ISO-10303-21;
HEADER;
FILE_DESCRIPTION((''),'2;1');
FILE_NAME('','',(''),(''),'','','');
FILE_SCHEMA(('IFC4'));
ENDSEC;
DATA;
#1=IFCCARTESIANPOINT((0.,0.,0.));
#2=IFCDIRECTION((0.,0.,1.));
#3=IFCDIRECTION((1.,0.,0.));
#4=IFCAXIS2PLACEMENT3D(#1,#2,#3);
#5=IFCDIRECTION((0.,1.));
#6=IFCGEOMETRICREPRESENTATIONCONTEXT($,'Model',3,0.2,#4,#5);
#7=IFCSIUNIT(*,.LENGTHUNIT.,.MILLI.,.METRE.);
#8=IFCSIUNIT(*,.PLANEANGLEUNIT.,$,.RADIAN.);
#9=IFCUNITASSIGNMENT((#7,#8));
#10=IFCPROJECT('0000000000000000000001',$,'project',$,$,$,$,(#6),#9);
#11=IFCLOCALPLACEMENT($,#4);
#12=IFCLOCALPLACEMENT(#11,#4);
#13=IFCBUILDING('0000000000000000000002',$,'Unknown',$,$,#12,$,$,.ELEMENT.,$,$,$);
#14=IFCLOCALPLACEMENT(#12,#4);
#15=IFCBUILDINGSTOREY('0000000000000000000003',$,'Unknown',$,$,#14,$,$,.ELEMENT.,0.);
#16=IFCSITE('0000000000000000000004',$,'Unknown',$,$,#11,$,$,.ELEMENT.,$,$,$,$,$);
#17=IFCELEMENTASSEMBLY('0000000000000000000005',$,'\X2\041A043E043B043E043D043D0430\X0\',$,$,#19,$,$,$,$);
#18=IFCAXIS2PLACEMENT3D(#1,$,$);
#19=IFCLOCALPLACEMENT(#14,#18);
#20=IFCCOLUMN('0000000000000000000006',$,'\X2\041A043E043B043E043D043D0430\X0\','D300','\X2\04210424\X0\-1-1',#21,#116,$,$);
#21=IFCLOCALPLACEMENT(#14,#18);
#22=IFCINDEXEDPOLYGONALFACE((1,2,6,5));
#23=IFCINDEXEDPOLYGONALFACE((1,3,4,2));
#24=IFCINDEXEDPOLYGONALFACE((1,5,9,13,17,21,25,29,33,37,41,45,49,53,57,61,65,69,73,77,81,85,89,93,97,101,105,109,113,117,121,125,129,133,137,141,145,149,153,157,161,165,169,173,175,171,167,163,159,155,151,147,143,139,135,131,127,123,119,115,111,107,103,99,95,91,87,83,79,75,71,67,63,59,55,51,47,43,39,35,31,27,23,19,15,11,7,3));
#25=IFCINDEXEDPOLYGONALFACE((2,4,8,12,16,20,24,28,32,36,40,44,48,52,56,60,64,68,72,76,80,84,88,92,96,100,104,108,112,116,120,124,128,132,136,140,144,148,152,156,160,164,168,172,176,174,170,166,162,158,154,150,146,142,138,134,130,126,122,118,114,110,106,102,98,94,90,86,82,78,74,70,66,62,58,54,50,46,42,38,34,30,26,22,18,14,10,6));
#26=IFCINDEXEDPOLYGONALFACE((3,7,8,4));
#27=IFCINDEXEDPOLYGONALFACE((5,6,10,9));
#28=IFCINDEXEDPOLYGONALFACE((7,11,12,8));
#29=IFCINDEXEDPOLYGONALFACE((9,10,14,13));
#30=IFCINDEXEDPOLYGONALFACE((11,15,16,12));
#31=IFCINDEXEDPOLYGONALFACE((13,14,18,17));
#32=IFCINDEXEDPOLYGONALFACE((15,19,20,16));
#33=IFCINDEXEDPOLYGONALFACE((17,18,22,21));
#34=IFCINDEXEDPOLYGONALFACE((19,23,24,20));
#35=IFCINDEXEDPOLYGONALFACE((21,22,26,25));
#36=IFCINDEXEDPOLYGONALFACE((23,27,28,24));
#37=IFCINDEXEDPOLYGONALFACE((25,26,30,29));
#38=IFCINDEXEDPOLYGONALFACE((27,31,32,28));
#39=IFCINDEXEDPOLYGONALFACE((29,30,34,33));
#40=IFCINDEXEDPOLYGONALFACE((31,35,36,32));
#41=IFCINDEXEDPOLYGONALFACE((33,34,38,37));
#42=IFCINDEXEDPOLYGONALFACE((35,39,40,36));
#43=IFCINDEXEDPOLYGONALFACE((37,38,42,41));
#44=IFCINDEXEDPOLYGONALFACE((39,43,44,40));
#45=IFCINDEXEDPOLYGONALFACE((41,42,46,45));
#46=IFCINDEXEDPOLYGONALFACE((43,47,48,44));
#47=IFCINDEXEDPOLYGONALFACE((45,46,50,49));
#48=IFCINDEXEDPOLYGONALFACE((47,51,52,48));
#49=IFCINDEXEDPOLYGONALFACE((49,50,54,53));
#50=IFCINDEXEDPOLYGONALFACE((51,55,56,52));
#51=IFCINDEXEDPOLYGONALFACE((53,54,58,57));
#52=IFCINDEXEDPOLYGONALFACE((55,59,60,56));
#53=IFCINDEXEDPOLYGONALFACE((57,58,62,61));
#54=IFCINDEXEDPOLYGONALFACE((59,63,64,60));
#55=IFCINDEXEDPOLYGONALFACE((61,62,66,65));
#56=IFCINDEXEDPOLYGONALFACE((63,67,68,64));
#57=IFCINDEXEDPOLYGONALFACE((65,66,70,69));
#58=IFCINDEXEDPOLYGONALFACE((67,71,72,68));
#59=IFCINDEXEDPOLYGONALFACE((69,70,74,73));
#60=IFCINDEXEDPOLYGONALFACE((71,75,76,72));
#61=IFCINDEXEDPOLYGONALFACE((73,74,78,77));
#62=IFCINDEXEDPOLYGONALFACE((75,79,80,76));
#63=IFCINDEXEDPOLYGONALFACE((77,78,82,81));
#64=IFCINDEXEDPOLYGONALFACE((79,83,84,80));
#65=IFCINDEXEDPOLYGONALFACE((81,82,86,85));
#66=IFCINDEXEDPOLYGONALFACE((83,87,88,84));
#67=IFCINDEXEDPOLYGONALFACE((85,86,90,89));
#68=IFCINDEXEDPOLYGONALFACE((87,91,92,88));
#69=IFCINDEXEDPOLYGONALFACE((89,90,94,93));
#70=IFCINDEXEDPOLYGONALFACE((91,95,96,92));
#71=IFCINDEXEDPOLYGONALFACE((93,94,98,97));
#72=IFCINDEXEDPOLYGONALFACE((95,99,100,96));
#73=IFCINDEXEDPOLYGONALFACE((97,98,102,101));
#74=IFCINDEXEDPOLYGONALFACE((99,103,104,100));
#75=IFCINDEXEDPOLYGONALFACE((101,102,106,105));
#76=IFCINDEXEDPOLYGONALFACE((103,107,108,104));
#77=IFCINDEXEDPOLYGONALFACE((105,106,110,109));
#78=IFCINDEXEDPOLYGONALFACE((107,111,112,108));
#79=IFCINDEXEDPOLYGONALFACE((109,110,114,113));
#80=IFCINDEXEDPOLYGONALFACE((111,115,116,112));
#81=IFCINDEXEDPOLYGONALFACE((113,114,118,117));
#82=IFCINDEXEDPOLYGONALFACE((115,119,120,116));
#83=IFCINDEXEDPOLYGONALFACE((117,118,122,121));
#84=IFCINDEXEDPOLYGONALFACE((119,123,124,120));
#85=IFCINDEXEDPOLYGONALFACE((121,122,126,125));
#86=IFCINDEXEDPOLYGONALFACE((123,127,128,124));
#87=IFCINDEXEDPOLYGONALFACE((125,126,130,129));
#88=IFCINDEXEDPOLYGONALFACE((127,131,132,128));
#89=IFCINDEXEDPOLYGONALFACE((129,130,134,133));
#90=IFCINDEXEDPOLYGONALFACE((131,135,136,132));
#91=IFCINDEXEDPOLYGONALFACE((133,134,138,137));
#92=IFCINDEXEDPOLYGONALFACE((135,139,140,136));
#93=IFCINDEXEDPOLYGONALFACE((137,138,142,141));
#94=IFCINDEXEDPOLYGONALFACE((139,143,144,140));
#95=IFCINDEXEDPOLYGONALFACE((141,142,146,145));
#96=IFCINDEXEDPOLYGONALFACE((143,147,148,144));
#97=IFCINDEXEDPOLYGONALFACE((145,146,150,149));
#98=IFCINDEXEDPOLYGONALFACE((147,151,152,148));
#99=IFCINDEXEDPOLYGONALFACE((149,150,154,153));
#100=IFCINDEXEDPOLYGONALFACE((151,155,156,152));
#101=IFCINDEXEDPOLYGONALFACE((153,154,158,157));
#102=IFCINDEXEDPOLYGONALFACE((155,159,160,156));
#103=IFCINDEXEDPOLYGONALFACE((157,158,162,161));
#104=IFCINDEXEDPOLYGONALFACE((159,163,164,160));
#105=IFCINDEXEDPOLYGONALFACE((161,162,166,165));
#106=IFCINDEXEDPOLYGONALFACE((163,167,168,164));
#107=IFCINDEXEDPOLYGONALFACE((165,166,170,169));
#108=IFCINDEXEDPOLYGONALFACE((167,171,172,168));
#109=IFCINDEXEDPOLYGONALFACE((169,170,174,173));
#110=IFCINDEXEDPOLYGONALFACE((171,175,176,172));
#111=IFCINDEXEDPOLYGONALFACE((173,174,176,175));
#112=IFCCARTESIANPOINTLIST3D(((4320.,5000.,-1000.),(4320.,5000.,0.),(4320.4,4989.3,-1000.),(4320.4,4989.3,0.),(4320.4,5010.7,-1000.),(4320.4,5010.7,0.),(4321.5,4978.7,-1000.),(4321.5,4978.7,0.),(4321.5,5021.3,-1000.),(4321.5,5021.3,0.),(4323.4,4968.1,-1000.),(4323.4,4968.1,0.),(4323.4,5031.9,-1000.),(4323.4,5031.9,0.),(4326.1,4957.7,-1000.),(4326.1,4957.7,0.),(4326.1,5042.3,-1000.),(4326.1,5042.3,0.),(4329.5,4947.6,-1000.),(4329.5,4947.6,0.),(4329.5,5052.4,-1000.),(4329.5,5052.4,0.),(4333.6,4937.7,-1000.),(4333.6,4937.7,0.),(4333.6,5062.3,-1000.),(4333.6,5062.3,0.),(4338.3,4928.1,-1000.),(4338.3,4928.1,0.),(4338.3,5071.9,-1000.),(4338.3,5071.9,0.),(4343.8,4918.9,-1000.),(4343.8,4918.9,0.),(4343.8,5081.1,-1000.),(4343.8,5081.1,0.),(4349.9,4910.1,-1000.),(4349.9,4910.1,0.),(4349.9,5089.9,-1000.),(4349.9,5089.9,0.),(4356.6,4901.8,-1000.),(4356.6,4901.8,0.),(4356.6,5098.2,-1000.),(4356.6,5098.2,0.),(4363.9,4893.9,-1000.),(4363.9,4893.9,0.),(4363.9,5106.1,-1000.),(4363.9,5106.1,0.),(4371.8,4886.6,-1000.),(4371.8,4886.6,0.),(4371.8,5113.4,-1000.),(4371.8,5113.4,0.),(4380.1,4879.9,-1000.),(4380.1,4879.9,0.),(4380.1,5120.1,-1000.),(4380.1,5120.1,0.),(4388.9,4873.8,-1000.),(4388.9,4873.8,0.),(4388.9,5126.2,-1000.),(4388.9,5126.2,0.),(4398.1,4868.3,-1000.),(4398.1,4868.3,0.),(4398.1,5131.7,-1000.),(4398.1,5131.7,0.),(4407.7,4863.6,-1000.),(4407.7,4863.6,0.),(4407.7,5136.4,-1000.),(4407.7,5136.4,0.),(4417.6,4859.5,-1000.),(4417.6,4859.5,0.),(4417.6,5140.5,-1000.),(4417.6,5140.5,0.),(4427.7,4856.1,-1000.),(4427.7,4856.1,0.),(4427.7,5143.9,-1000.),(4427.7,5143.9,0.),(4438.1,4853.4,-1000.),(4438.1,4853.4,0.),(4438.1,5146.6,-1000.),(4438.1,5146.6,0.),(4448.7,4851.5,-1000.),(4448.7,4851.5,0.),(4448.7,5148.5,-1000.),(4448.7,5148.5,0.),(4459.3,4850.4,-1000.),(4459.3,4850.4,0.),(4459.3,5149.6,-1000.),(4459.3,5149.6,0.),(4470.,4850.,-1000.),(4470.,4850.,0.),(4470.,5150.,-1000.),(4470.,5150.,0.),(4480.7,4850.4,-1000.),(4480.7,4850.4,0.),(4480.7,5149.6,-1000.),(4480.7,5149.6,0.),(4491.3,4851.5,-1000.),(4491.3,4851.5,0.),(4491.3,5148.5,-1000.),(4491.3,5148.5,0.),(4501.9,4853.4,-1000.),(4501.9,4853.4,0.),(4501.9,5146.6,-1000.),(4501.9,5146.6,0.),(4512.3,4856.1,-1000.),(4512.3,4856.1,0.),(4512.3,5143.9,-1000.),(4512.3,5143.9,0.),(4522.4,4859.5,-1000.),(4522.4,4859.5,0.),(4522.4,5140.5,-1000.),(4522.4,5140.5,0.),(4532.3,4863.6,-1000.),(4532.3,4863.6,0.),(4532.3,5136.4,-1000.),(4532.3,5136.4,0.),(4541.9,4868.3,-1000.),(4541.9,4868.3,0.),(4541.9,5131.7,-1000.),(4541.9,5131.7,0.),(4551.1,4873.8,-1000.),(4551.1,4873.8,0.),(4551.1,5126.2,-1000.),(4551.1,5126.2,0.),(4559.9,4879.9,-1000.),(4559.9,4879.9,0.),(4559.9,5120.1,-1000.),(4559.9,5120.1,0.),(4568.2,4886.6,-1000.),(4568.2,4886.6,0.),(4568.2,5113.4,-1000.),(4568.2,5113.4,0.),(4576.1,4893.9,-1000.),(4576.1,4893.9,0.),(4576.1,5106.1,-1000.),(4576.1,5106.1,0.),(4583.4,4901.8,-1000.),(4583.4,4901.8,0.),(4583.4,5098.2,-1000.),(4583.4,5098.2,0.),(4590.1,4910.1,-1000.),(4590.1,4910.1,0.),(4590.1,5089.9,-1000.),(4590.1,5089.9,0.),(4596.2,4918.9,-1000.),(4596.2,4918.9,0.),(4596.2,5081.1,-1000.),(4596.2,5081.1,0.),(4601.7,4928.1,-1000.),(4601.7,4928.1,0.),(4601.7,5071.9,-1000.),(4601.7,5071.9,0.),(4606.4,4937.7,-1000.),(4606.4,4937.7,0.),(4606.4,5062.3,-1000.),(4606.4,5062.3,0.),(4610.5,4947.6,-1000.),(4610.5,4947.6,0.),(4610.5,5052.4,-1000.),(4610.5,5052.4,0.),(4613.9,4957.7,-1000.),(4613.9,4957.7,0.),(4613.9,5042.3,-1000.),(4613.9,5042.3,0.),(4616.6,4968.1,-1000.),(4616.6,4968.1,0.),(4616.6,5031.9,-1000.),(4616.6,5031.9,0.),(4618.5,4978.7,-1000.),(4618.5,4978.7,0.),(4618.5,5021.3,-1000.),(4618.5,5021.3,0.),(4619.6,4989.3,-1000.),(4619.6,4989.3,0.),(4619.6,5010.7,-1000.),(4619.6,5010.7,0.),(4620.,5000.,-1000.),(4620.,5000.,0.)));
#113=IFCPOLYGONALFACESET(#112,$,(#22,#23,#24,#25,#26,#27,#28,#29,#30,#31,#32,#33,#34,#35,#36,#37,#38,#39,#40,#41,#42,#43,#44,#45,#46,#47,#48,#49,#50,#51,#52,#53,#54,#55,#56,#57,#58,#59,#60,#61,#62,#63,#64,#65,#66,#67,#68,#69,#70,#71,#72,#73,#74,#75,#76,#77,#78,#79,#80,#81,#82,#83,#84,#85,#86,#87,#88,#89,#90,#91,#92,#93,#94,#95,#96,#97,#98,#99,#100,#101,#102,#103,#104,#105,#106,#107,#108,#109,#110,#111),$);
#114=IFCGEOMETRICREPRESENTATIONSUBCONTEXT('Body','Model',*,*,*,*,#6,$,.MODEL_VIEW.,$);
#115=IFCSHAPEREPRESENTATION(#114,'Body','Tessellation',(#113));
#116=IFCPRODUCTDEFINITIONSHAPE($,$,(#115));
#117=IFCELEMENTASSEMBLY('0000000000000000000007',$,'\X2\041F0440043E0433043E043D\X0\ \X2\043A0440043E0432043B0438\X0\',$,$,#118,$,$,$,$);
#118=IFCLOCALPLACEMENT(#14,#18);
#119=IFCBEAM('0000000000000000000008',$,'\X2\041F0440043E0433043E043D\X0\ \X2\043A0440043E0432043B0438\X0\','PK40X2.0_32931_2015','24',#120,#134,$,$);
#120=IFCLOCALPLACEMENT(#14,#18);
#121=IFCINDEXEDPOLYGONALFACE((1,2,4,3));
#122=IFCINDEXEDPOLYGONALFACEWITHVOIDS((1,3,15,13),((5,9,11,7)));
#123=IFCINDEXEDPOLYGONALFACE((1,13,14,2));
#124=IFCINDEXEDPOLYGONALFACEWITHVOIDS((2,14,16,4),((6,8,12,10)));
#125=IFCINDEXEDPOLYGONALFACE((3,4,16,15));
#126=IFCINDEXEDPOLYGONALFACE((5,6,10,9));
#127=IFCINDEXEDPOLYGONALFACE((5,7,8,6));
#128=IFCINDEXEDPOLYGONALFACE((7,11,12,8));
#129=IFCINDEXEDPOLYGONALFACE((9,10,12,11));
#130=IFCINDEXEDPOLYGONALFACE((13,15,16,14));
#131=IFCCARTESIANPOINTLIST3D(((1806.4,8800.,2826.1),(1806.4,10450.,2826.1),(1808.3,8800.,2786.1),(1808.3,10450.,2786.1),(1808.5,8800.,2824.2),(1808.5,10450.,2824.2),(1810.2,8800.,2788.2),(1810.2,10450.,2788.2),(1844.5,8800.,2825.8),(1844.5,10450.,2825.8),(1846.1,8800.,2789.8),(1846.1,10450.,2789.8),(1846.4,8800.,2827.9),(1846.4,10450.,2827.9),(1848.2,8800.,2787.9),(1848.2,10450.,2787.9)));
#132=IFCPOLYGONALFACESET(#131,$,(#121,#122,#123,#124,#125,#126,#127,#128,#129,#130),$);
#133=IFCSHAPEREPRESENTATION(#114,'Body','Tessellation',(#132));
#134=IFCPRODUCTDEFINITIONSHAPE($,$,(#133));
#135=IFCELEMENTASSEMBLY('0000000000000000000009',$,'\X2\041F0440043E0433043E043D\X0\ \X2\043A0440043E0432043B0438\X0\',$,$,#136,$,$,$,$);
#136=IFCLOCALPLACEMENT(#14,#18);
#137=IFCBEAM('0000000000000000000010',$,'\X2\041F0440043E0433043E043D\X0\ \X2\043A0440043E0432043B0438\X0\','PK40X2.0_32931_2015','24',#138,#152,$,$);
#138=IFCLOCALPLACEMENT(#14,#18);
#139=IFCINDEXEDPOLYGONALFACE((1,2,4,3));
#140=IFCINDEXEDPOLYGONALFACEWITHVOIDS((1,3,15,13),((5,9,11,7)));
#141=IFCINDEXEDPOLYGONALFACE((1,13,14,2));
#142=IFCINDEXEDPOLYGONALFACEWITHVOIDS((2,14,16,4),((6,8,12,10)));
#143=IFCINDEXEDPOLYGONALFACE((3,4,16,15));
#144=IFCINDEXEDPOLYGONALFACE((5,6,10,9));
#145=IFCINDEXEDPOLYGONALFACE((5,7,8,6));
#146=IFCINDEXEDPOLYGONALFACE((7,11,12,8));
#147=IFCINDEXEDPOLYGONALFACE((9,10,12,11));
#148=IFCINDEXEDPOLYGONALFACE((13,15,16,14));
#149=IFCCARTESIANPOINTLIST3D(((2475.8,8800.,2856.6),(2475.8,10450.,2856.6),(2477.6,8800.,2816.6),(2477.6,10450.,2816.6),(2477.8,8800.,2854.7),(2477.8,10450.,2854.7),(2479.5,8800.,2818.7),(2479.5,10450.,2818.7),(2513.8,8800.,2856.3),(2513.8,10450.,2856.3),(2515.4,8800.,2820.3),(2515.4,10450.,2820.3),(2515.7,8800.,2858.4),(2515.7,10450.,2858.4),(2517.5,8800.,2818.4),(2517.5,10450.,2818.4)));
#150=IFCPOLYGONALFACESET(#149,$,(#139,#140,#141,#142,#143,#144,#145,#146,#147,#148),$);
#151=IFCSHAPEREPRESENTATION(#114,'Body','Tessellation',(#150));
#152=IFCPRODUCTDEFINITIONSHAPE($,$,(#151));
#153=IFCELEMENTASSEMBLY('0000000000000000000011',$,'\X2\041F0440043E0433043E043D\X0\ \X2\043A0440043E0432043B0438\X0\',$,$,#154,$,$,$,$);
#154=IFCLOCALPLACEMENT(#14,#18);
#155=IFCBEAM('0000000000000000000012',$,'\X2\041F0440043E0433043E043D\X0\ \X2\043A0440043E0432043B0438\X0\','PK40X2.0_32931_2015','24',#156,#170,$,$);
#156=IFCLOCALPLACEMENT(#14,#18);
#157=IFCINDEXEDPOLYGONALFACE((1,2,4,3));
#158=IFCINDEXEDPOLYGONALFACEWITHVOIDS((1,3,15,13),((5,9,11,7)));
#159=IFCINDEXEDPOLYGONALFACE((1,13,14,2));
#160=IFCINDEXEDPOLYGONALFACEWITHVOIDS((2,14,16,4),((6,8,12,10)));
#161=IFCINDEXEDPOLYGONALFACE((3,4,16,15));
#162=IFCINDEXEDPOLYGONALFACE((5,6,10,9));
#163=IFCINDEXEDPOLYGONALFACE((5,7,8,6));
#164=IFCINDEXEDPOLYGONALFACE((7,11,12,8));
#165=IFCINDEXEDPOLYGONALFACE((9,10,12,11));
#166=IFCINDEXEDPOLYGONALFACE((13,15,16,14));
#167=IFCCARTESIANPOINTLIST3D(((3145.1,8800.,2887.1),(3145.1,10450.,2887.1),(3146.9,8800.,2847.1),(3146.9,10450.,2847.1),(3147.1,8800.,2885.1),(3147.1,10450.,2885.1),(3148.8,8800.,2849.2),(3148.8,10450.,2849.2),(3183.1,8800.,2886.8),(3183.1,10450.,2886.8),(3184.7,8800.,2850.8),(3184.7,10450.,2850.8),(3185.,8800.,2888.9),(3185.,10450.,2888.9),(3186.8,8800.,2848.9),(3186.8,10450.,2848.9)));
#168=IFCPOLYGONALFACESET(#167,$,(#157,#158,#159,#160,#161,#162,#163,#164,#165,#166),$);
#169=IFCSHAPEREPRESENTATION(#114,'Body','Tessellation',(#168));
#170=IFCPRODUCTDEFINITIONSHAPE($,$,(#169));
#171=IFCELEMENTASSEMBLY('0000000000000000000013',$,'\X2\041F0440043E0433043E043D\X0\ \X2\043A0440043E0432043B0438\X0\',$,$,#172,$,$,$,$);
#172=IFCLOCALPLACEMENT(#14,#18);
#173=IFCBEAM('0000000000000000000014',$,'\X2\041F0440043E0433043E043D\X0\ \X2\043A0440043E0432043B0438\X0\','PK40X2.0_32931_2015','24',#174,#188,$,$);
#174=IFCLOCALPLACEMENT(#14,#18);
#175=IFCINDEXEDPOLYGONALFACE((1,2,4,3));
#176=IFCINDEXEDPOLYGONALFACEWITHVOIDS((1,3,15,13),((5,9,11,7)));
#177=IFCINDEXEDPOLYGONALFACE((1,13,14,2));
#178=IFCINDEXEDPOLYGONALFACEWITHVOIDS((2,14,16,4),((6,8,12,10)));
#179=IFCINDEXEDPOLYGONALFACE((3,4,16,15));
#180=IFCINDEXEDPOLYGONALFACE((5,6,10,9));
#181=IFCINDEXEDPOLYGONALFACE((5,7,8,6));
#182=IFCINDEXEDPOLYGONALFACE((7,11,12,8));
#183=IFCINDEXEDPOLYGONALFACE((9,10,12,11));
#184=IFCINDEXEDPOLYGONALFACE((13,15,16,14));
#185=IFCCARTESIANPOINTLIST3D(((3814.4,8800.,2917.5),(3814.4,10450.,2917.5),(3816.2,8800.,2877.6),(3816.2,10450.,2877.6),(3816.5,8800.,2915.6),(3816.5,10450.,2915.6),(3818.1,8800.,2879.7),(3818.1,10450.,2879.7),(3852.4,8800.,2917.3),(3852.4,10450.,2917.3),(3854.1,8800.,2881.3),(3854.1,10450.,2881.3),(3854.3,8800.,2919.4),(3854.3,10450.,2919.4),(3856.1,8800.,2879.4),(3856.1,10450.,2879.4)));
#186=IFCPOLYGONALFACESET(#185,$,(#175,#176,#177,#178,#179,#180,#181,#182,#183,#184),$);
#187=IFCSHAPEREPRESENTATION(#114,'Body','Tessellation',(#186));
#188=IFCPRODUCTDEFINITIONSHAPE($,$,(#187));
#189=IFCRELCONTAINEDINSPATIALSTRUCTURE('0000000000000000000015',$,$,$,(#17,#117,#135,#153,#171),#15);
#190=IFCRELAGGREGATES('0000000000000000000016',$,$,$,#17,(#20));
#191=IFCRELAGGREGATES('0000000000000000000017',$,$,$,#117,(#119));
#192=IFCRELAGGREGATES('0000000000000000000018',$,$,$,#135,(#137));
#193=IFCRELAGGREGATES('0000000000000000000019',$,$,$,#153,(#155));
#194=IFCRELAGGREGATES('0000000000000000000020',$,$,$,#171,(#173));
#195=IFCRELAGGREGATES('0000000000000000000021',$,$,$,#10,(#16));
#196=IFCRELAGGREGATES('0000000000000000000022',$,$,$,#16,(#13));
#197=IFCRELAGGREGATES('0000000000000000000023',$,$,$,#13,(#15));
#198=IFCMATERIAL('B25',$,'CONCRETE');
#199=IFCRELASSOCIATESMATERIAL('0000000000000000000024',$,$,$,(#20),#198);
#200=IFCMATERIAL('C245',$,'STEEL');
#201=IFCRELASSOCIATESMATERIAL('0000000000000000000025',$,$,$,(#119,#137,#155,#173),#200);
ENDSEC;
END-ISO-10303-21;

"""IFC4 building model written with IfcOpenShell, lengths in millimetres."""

from ifc_helpers import new_model, si_unit, direction, frame, origin_with_axes, place, context, subcontext, project, spatial, line, indexed_curve, outline, extrude, material, element, aggregate, save


model = new_model("IFC4")

# Units and contexts
model_context = context("Model", 3, precision=0.2, world=origin_with_axes(), true_north=direction((0.0, 1.0)))
body_context = subcontext(model_context, "Body", "Model", "MODEL_VIEW")
ifc_project = project(units=[si_unit("LENGTHUNIT", "METRE", prefix="MILLI"), si_unit("PLANEANGLEUNIT", "RADIAN")], contexts=[model_context])

# Site, building, storey
site_placement = place(None, origin_with_axes())
site = spatial("IfcSite", under=ifc_project, at=site_placement, Name="Unknown", CompositionType="ELEMENT")
building_placement = place(site_placement, origin_with_axes())
building = spatial("IfcBuilding", under=site, at=building_placement, Name="Unknown", CompositionType="ELEMENT")
storey_placement = place(building_placement, origin_with_axes())
storey = spatial("IfcBuildingStorey", under=building, at=storey_placement, Name="Unknown", CompositionType="ELEMENT", Elevation=0.0)

# Shared definitions
ifc_material_1 = material(Name="C245", Category="STEEL")
placement_1 = place(storey_placement, frame((4470.0, 5000.0, -1000.0), z_axis=(-1.0, 0.0, 0.0), x_axis=(0.0, 0.0, 1.0)))
placement_2 = place(placement_1, origin_with_axes())

# Element assembly, column
ifc_material_2 = material(Name="B25", Category="CONCRETE")
assembly_1 = element("IfcElementAssembly", 1, at=placement_1, inside=storey, Name="Колонна")
column_1 = element("IfcColumn", 2, at=placement_2, material=ifc_material_2, Name="Колонна", Description="D300", ObjectType="СФ-1-1", context=body_context, shape_type="SolidModel", body=[
    extrude(outline(indexed_curve([(150.0, 0.0), (149.6, 10.7), (148.5, 21.3), (146.6, 31.9), (143.9, 42.3), (140.5, 52.4), (136.4, 62.3), (131.7, 71.9), (126.2, 81.1), (120.1, 89.9), (113.4, 98.2), (106.1, 106.1), (98.2, 113.4), (89.9, 120.1), (81.1, 126.2), (71.9, 131.7), (62.3, 136.4), (52.4, 140.5), (42.3, 143.9), (31.9, 146.6), (21.3, 148.5), (10.7, 149.6), (0.0, 150.0), (-10.7, 149.6), (-21.3, 148.5), (-31.9, 146.6), (-42.3, 143.9), (-52.4, 140.5), (-62.3, 136.4), (-71.9, 131.7), (-81.1, 126.2), (-89.9, 120.1), (-98.2, 113.4), (-106.1, 106.1), (-113.4, 98.2), (-120.1, 89.9), (-126.2, 81.1), (-131.7, 71.9), (-136.4, 62.3), (-140.5, 52.4), (-143.9, 42.3), (-146.6, 31.9), (-148.5, 21.3), (-149.6, 10.7), (-150.0, 0.0), (-149.6, -10.7), (-148.5, -21.3), (-146.6, -31.9), (-143.9, -42.3), (-140.5, -52.4), (-136.4, -62.3), (-131.7, -71.9), (-126.2, -81.1), (-120.1, -89.9), (-113.4, -98.2), (-106.1, -106.1), (-98.2, -113.4), (-89.9, -120.1), (-81.1, -126.2), (-71.9, -131.7), (-62.3, -136.4), (-52.4, -140.5), (-42.3, -143.9), (-31.9, -146.6), (-21.3, -148.5), (-10.7, -149.6), (0.0, -150.0), (10.7, -149.6), (21.3, -148.5), (31.9, -146.6), (42.3, -143.9), (52.4, -140.5), (62.3, -136.4), (71.9, -131.7), (81.1, -126.2), (89.9, -120.1), (98.2, -113.4), (106.1, -106.1), (113.4, -98.2), (120.1, -89.9), (126.2, -81.1), (131.7, -71.9), (136.4, -62.3), (140.5, -52.4), (143.9, -42.3), (146.6, -31.9), (148.5, -21.3), (149.6, -10.7)], segments=[line(1, 2, 3, 4, 5, 6, 7, 8, 9, 10, 11, 12, 13, 14, 15, 16, 17, 18, 19, 20, 21, 22, 23, 24, 25, 26, 27, 28, 29, 30, 31, 32, 33, 34, 35, 36, 37, 38, 39, 40, 41, 42, 43, 44, 45, 46, 47, 48, 49, 50, 51, 52, 53, 54, 55, 56, 57, 58, 59, 60, 61, 62, 63, 64, 65, 66, 67, 68, 69, 70, 71, 72, 73, 74, 75, 76, 77, 78, 79, 80, 81, 82, 83, 84, 85, 86, 87, 88, 1)])), frame((0.0, 0.0, 0.0), z_axis=(-1.0, 0.0, 0.0), x_axis=(0.0, 0.0, 1.0)), (0.0, 0.0, -1.0), 1000.0),
])
aggregate(assembly_1, [column_1])

# Element assemblies, beams
assembly_2_placement = place(storey_placement, frame((1827.3, 10450.0, 2807.0), z_axis=(-0.998964, 0.0, -0.045508), x_axis=(0.0, -1.0, 0.0)))
assembly_2 = element("IfcElementAssembly", 3, at=assembly_2_placement, inside=storey, Name="Прогон кровли")
beam_1_placement = place(assembly_2_placement, origin_with_axes())
beam_1 = element("IfcBeam", 4, at=beam_1_placement, material=ifc_material_1, Name="Прогон кровли", Description="PK40X2.0_32931_2015", ObjectType="24", context=body_context, shape_type="SolidModel", body=[
    extrude(outline(indexed_curve([(-20.0, -20.0), (20.0, -20.0), (20.0, 20.0), (-20.0, 20.0)], segments=[line(1, 2, 3, 4, 1)]), holes=[indexed_curve([(-18.0, -18.0), (-18.0, 18.0), (18.0, 18.0), (18.0, -18.0)], segments=[line(1, 2, 3, 4, 1)])]), frame((0.0, 0.0, 0.0), z_axis=(-1.0, 0.0, 0.0), x_axis=(0.0, 0.0, 1.0)), (0.0, 0.0, -1.0), 1650.0),
])
aggregate(assembly_2, [beam_1])
assembly_3_placement = place(storey_placement, frame((2496.6, 10450.0, 2837.5), z_axis=(-0.998964, 0.0, -0.045508), x_axis=(0.0, -1.0, 0.0)))
assembly_3 = element("IfcElementAssembly", 5, at=assembly_3_placement, inside=storey, Name="Прогон кровли")
beam_2_placement = place(assembly_3_placement, origin_with_axes())
beam_2 = element("IfcBeam", 6, at=beam_2_placement, material=ifc_material_1, Name="Прогон кровли", Description="PK40X2.0_32931_2015", ObjectType="24", context=body_context, shape_type="SolidModel", body=[
    extrude(outline(indexed_curve([(-20.0, -20.0), (20.0, -20.0), (20.0, 20.0), (-20.0, 20.0)], segments=[line(1, 2, 3, 4, 1)]), holes=[indexed_curve([(-18.0, -18.0), (-18.0, 18.0), (18.0, 18.0), (18.0, -18.0)], segments=[line(1, 2, 3, 4, 1)])]), frame((0.0, 0.0, 0.0), z_axis=(-1.0, 0.0, 0.0), x_axis=(0.0, 0.0, 1.0)), (0.0, 0.0, -1.0), 1650.0),
])
aggregate(assembly_3, [beam_2])
assembly_4_placement = place(storey_placement, frame((3165.9, 10450.0, 2868.0), z_axis=(-0.998964, 0.0, -0.045508), x_axis=(0.0, -1.0, 0.0)))
assembly_4 = element("IfcElementAssembly", 7, at=assembly_4_placement, inside=storey, Name="Прогон кровли")
beam_3_placement = place(assembly_4_placement, origin_with_axes())
beam_3 = element("IfcBeam", 8, at=beam_3_placement, material=ifc_material_1, Name="Прогон кровли", Description="PK40X2.0_32931_2015", ObjectType="24", context=body_context, shape_type="SolidModel", body=[
    extrude(outline(indexed_curve([(-20.0, -20.0), (20.0, -20.0), (20.0, 20.0), (-20.0, 20.0)], segments=[line(1, 2, 3, 4, 1)]), holes=[indexed_curve([(-18.0, -18.0), (-18.0, 18.0), (18.0, 18.0), (18.0, -18.0)], segments=[line(1, 2, 3, 4, 1)])]), frame((0.0, 0.0, 0.0), z_axis=(-1.0, 0.0, 0.0), x_axis=(0.0, 0.0, 1.0)), (0.0, 0.0, -1.0), 1650.0),
])
aggregate(assembly_4, [beam_3])
assembly_5_placement = place(storey_placement, frame((3835.3, 10450.0, 2898.5), z_axis=(-0.998964, 0.0, -0.045508), x_axis=(0.0, -1.0, 0.0)))
assembly_5 = element("IfcElementAssembly", 9, at=assembly_5_placement, inside=storey, Name="Прогон кровли")
beam_4_placement = place(assembly_5_placement, origin_with_axes())
beam_4 = element("IfcBeam", 10, at=beam_4_placement, material=ifc_material_1, Name="Прогон кровли", Description="PK40X2.0_32931_2015", ObjectType="24", context=body_context, shape_type="SolidModel", body=[
    extrude(outline(indexed_curve([(-20.0, -20.0), (20.0, -20.0), (20.0, 20.0), (-20.0, 20.0)], segments=[line(1, 2, 3, 4, 1)]), holes=[indexed_curve([(-18.0, -18.0), (-18.0, 18.0), (18.0, 18.0), (18.0, -18.0)], segments=[line(1, 2, 3, 4, 1)])]), frame((0.0, 0.0, 0.0), z_axis=(-1.0, 0.0, 0.0), x_axis=(0.0, 0.0, 1.0)), (0.0, 0.0, -1.0), 1650.0),
])
aggregate(assembly_5, [beam_4])

save(model, "model.ifc")
